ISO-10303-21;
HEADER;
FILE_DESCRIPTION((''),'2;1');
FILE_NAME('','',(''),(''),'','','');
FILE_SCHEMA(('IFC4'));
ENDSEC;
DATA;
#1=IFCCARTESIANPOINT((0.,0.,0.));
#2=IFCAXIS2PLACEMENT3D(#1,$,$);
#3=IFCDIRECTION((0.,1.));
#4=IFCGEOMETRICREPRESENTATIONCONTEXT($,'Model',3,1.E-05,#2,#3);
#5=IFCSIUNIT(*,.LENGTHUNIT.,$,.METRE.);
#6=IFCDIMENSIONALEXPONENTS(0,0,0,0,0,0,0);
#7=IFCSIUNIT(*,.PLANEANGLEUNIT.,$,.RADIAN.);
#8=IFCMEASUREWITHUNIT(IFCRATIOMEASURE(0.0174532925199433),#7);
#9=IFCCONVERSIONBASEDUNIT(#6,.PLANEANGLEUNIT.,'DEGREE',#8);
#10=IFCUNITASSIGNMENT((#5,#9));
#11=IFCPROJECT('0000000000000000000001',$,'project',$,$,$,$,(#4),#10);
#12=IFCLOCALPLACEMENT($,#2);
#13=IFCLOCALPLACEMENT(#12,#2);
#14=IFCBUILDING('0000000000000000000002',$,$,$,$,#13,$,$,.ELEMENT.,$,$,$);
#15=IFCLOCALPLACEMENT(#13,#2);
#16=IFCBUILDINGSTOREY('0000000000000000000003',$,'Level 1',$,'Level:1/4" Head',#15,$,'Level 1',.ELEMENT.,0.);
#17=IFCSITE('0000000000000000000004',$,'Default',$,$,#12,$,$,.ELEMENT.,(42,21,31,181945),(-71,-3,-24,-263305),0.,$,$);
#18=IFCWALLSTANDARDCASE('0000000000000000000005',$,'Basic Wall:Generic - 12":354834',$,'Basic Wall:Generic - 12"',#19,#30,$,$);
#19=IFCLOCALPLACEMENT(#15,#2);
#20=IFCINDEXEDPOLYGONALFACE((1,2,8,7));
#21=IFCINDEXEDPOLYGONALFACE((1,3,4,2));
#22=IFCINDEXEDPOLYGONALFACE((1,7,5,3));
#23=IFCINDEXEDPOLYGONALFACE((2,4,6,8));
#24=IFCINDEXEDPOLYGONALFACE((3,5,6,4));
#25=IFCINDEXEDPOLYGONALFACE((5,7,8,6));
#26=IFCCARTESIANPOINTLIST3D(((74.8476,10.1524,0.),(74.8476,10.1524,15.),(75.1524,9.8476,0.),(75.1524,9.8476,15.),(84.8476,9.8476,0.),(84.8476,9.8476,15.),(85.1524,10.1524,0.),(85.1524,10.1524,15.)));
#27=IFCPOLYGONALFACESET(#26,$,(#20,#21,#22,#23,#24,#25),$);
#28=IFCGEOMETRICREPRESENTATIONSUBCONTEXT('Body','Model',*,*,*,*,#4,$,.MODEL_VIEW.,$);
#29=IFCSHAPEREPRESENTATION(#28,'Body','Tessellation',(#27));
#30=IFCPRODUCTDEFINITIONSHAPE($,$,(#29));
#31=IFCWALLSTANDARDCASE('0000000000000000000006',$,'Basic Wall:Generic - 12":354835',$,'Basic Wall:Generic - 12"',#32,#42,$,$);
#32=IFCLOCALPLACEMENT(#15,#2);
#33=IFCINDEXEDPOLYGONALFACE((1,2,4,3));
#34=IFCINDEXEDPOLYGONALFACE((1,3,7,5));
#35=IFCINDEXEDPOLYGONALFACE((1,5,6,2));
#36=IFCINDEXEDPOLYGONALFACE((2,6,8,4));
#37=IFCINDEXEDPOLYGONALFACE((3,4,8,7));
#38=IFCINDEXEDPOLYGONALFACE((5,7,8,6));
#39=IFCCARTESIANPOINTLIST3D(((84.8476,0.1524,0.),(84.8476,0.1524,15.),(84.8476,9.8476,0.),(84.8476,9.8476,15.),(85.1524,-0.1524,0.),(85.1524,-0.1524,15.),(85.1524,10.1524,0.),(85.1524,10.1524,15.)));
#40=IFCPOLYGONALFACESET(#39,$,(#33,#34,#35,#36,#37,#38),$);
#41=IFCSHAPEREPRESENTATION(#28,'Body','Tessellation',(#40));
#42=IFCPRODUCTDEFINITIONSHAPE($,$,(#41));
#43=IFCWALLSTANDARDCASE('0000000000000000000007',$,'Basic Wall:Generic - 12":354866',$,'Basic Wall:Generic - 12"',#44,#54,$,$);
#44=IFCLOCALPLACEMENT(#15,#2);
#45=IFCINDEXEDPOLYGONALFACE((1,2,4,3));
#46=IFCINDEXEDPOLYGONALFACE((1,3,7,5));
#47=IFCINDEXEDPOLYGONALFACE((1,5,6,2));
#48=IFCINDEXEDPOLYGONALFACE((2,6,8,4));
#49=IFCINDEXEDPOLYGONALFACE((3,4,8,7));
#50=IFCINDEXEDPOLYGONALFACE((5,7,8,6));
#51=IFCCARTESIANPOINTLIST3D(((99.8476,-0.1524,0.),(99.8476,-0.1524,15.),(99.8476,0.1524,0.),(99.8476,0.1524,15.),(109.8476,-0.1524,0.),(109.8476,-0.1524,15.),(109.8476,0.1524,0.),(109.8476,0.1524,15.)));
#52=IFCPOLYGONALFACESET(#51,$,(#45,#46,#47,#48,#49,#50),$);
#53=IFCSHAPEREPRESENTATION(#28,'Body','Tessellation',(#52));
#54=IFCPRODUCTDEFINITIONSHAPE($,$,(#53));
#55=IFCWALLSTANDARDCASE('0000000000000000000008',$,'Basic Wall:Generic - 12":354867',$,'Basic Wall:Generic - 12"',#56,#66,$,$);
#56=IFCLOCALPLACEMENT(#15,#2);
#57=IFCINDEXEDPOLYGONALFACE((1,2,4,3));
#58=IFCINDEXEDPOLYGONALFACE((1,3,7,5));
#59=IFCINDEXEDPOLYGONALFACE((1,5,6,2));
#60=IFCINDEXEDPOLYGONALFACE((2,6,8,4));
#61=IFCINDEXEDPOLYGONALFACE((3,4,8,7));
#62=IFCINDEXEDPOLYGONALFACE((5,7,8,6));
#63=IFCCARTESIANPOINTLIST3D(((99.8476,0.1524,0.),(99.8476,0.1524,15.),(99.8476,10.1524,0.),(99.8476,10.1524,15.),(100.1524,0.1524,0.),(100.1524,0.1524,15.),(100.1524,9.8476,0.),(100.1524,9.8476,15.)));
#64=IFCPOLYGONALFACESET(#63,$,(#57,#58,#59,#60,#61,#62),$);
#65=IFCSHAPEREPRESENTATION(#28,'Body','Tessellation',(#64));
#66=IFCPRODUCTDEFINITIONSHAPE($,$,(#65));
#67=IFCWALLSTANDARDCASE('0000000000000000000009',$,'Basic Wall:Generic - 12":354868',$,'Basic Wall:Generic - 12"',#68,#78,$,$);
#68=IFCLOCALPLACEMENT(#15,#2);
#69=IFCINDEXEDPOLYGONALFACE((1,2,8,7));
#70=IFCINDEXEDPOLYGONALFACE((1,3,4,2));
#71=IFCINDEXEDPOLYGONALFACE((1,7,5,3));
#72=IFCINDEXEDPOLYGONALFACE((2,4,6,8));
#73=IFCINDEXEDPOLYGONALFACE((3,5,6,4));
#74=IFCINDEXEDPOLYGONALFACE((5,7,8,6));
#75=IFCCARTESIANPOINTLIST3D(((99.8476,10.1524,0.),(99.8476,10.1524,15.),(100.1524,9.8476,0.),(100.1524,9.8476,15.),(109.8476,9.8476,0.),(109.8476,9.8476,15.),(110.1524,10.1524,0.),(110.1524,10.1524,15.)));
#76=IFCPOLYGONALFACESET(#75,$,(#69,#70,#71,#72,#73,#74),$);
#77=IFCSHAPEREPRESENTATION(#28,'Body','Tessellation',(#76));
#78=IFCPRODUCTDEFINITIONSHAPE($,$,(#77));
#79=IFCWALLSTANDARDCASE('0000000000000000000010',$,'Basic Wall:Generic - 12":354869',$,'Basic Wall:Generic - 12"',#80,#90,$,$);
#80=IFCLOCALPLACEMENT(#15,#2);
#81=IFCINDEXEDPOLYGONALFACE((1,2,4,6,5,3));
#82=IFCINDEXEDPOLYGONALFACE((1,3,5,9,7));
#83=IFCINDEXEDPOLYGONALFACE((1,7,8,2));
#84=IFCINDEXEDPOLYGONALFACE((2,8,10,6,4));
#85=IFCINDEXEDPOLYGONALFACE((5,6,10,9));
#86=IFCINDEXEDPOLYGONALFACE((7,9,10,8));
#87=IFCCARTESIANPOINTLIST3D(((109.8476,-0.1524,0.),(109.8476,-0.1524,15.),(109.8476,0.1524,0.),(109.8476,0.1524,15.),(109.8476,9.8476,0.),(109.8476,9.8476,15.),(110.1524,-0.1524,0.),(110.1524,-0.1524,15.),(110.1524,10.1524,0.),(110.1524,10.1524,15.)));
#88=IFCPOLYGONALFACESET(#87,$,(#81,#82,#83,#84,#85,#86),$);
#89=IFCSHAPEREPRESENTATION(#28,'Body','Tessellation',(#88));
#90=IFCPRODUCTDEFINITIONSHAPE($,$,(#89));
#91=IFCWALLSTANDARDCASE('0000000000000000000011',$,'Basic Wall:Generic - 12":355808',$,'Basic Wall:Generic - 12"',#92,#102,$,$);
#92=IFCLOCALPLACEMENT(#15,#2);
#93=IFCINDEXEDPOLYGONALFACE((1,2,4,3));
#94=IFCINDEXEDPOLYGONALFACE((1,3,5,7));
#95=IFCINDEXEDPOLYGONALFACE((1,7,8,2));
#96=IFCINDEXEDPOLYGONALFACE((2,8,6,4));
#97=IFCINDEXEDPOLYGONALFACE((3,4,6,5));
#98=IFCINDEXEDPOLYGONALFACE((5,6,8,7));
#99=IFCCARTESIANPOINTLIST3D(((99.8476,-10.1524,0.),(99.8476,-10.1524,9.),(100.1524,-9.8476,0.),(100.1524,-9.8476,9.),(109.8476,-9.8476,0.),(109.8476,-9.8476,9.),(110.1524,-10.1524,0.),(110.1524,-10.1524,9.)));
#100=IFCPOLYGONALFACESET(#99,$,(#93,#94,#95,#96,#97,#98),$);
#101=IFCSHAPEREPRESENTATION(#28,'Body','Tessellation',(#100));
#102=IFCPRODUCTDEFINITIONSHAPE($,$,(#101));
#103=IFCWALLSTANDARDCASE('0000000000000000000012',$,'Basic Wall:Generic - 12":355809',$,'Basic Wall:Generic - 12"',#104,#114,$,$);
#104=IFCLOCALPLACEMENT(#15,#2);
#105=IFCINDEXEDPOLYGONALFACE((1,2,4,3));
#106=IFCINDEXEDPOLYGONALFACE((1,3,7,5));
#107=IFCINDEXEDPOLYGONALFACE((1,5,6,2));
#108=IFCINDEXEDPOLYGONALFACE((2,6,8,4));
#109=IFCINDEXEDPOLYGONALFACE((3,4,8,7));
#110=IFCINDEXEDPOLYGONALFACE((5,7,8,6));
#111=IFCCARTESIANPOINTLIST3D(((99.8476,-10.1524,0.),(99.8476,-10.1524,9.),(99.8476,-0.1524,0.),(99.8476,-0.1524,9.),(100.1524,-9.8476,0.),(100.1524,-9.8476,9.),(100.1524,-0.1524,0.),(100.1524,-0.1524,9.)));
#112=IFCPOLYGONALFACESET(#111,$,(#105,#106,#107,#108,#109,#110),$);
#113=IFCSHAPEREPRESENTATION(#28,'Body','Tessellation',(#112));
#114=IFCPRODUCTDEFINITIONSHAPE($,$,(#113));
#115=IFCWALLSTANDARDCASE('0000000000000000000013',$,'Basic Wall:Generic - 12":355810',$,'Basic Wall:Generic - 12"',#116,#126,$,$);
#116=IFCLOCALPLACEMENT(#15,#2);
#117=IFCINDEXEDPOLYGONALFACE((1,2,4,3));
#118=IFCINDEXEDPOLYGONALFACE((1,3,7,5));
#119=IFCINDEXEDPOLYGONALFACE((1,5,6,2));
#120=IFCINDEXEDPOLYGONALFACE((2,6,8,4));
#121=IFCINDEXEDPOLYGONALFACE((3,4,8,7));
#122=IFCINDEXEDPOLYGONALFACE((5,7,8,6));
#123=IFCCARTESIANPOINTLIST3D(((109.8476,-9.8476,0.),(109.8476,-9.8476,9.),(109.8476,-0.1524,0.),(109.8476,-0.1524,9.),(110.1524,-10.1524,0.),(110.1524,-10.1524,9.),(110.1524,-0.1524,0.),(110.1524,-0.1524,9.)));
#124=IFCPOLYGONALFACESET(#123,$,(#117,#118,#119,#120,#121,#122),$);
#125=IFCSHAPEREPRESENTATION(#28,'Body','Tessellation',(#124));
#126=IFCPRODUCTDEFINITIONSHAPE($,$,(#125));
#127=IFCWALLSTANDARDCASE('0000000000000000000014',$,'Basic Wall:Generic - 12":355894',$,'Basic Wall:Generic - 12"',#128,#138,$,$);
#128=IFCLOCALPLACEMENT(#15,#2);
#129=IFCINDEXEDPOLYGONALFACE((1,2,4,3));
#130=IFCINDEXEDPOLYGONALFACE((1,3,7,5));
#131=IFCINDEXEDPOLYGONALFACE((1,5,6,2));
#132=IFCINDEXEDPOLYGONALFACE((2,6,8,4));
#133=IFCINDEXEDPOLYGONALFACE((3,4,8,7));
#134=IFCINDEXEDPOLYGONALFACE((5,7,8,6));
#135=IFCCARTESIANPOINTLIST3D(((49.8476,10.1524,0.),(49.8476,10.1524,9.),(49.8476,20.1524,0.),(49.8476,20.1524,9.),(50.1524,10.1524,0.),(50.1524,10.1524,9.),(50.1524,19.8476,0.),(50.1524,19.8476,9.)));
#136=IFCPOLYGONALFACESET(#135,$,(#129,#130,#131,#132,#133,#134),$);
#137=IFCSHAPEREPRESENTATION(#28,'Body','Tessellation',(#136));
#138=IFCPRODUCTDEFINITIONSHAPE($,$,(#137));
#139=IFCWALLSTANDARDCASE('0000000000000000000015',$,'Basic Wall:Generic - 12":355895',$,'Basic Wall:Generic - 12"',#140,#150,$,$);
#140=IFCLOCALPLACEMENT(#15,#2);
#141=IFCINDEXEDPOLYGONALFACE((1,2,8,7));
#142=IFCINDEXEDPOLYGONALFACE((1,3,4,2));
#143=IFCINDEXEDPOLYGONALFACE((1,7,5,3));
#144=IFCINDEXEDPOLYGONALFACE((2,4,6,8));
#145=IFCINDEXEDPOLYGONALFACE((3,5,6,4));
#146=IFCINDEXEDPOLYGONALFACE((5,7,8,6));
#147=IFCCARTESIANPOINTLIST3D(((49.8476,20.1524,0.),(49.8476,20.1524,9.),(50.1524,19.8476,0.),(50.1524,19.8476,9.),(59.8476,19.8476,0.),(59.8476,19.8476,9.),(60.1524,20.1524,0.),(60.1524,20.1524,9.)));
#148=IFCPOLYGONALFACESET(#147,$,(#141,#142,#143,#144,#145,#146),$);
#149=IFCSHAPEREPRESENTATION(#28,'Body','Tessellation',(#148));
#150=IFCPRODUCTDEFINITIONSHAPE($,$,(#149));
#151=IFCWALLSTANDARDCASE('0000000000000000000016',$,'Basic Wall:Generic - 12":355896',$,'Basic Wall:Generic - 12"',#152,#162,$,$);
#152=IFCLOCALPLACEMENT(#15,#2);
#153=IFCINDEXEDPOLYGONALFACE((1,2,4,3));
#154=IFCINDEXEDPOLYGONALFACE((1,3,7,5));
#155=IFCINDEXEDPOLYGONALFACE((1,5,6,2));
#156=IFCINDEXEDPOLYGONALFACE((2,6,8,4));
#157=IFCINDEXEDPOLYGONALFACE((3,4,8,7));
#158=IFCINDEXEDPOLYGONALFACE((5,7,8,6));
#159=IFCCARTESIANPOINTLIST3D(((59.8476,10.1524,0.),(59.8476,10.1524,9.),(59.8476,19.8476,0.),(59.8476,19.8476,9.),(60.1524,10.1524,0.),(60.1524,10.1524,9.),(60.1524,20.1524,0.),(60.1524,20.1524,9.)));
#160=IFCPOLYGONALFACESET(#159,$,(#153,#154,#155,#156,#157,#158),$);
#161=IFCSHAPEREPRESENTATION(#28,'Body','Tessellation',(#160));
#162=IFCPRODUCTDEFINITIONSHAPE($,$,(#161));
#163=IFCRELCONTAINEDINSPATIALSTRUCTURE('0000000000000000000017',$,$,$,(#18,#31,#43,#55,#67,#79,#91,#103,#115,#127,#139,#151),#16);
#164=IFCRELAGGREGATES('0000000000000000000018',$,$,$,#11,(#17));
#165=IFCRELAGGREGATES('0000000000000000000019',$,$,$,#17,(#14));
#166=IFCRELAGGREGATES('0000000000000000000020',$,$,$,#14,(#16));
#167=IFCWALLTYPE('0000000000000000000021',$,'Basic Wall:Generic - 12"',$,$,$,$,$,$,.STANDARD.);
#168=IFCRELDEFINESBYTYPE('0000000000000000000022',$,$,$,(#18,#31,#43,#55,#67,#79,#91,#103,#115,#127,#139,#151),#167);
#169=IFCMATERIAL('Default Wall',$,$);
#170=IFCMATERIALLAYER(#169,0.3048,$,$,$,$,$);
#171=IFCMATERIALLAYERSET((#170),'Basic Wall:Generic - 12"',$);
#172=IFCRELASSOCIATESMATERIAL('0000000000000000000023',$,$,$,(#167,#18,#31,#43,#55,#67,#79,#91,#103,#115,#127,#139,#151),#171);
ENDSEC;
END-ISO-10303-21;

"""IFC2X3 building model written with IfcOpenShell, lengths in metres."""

from ifc_helpers import new_model, entity, si_unit, converted_unit, direction, frame, frame_2d, origin, place, context, subcontext, project, spatial, polyline, rectangle, outline, extrude, material, layer, layer_set, layer_usage, type_object, element, save


model = new_model("IFC2X3")

# Units and contexts
model_context = context("Model", 3, precision=1e-05, world=origin(), true_north=direction((0.0, 1.0)))
body_context = subcontext(model_context, "Body", "Model", "MODEL_VIEW")
ifc_project = project(units=[si_unit("LENGTHUNIT", "METRE"), converted_unit("PLANEANGLEUNIT", "DEGREE", entity("IfcRatioMeasure", 0.0174532925199433), si_unit("PLANEANGLEUNIT", "RADIAN"), dimensions=[0, 0, 0, 0, 0, 0, 0])], contexts=[model_context])

# Site, building, storey
site_placement = place(None, origin())
site = spatial("IfcSite", under=ifc_project, at=site_placement, Name="Default", CompositionType="ELEMENT", RefLatitude=(42, 21, 31, 181945), RefLongitude=(-71, -3, -24, -263305), RefElevation=0.0)
building_placement = place(site_placement, origin())
building = spatial("IfcBuilding", under=site, at=building_placement, CompositionType="ELEMENT")
storey_placement = place(building_placement, origin())
storey = spatial("IfcBuildingStorey", under=building, at=storey_placement, Name="Level 1", ObjectType="Level:1/4\" Head", LongName="Level 1", CompositionType="ELEMENT", Elevation=0.0)

# Walls
ifc_material = material(Name="Default Wall")
ifc_layer = layer(ifc_material, 0.3048)
ifc_layer_set = layer_set([ifc_layer], Name="Basic Wall:Generic - 12\"")
wall_type = type_object("IfcWallType", Name="Basic Wall:Generic - 12\"", PredefinedType="STANDARD", material=ifc_layer_set)
ifc_layer_usage_1 = layer_usage(ifc_layer_set, "AXIS2", "NEGATIVE", 0.1524)
wall_1_placement = place(storey_placement, frame((85.1524, 10.0, 0.0), z_axis=(0.0, 0.0, 1.0), x_axis=(-1.0, 0.0, 0.0)))
element("IfcWallStandardCase", 1, at=wall_1_placement, inside=storey, type_object=wall_type, material=ifc_layer_usage_1, Name="Basic Wall:Generic - 12\":354834", ObjectType="Basic Wall:Generic - 12\"", context=body_context, shape_type="SweptSolid", body=[
    extrude(outline(polyline([(10.3048, -0.1524), (10.0, 0.1524), (0.3048, 0.1524), (0.0, -0.1524), (10.3048, -0.1524)])), origin(), (0.0, 0.0, 1.0), 15.0),
])
ifc_layer_usage_2 = layer_usage(ifc_layer_set, "AXIS2", "NEGATIVE", 0.1524)
wall_2_placement = place(storey_placement, frame((85.0, -0.1524, 0.0), z_axis=(0.0, 0.0, 1.0), x_axis=(0.0, 1.0, 0.0)))
element("IfcWallStandardCase", 2, at=wall_2_placement, inside=storey, type_object=wall_type, material=ifc_layer_usage_2, Name="Basic Wall:Generic - 12\":354835", ObjectType="Basic Wall:Generic - 12\"", context=body_context, shape_type="SweptSolid", body=[
    extrude(outline(polyline([(10.3048, -0.1524), (10.0, 0.1524), (0.3048, 0.1524), (0.0, -0.1524), (10.3048, -0.1524)])), origin(), (0.0, 0.0, 1.0), 15.0),
])
ifc_layer_usage_3 = layer_usage(ifc_layer_set, "AXIS2", "NEGATIVE", 0.1524)
wall_3_placement = place(storey_placement, frame((99.8476, 0.0, 0.0)))
element("IfcWallStandardCase", 3, at=wall_3_placement, inside=storey, type_object=wall_type, material=ifc_layer_usage_3, Name="Basic Wall:Generic - 12\":354866", ObjectType="Basic Wall:Generic - 12\"", context=body_context, shape_type="SweptSolid", body=[
    extrude(rectangle(XDim=10.0, YDim=0.3048, at=frame_2d((5.0, 0.0), x_axis=(-1.0, 0.0))), origin(), (0.0, 0.0, 1.0), 15.0),
])
ifc_layer_usage_4 = layer_usage(ifc_layer_set, "AXIS2", "NEGATIVE", 0.1524)
wall_4_placement = place(storey_placement, frame((100.0, 10.1524, 0.0), z_axis=(0.0, 0.0, 1.0), x_axis=(0.0, -1.0, 0.0)))
element("IfcWallStandardCase", 4, at=wall_4_placement, inside=storey, type_object=wall_type, material=ifc_layer_usage_4, Name="Basic Wall:Generic - 12\":354867", ObjectType="Basic Wall:Generic - 12\"", context=body_context, shape_type="SweptSolid", body=[
    extrude(outline(polyline([(10.0, -0.1524), (10.0, 0.1524), (0.3048, 0.1524), (0.0, -0.1524), (10.0, -0.1524)])), origin(), (0.0, 0.0, 1.0), 15.0),
])
ifc_layer_usage_5 = layer_usage(ifc_layer_set, "AXIS2", "NEGATIVE", 0.1524)
wall_5_placement = place(storey_placement, frame((110.1524, 10.0, 0.0), z_axis=(0.0, 0.0, 1.0), x_axis=(-1.0, 0.0, 0.0)))
element("IfcWallStandardCase", 5, at=wall_5_placement, inside=storey, type_object=wall_type, material=ifc_layer_usage_5, Name="Basic Wall:Generic - 12\":354868", ObjectType="Basic Wall:Generic - 12\"", context=body_context, shape_type="SweptSolid", body=[
    extrude(outline(polyline([(10.3048, -0.1524), (10.0, 0.1524), (0.3048, 0.1524), (0.0, -0.1524), (10.3048, -0.1524)])), origin(), (0.0, 0.0, 1.0), 15.0),
])
ifc_layer_usage_6 = layer_usage(ifc_layer_set, "AXIS2", "NEGATIVE", 0.1524)
wall_6_placement = place(storey_placement, frame((110.0, -0.1524, 0.0), z_axis=(0.0, 0.0, 1.0), x_axis=(0.0, 1.0, 0.0)))
element("IfcWallStandardCase", 6, at=wall_6_placement, inside=storey, type_object=wall_type, material=ifc_layer_usage_6, Name="Basic Wall:Generic - 12\":354869", ObjectType="Basic Wall:Generic - 12\"", context=body_context, shape_type="SweptSolid", body=[
    extrude(outline(polyline([(10.3048, -0.1524), (10.0, 0.1524), (0.3048, 0.1524), (0.0, 0.1524), (0.0, -0.1524), (10.3048, -0.1524)])), origin(), (0.0, 0.0, 1.0), 15.0),
])
ifc_layer_usage_7 = layer_usage(ifc_layer_set, "AXIS2", "NEGATIVE", 0.1524)
wall_7_placement = place(storey_placement, frame((99.8476, -10.0, 0.0)))
element("IfcWallStandardCase", 7, at=wall_7_placement, inside=storey, type_object=wall_type, material=ifc_layer_usage_7, Name="Basic Wall:Generic - 12\":355808", ObjectType="Basic Wall:Generic - 12\"", context=body_context, shape_type="SweptSolid", body=[
    extrude(outline(polyline([(10.3048, -0.1524), (10.0, 0.1524), (0.3048, 0.1524), (0.0, -0.1524), (10.3048, -0.1524)])), origin(), (0.0, 0.0, 1.0), 9.0),
])
ifc_layer_usage_8 = layer_usage(ifc_layer_set, "AXIS2", "NEGATIVE", 0.1524)
wall_8_placement = place(storey_placement, frame((100.0, -0.1524, 0.0), z_axis=(0.0, 0.0, 1.0), x_axis=(0.0, -1.0, 0.0)))
element("IfcWallStandardCase", 8, at=wall_8_placement, inside=storey, type_object=wall_type, material=ifc_layer_usage_8, Name="Basic Wall:Generic - 12\":355809", ObjectType="Basic Wall:Generic - 12\"", context=body_context, shape_type="SweptSolid", body=[
    extrude(outline(polyline([(10.0, -0.1524), (9.6952, 0.1524), (0.0, 0.1524), (0.0, -0.1524), (10.0, -0.1524)])), origin(), (0.0, 0.0, 1.0), 9.0),
])
ifc_layer_usage_9 = layer_usage(ifc_layer_set, "AXIS2", "NEGATIVE", 0.1524)
wall_9_placement = place(storey_placement, frame((110.0, -10.1524, 0.0), z_axis=(0.0, 0.0, 1.0), x_axis=(0.0, 1.0, 0.0)))
element("IfcWallStandardCase", 9, at=wall_9_placement, inside=storey, type_object=wall_type, material=ifc_layer_usage_9, Name="Basic Wall:Generic - 12\":355810", ObjectType="Basic Wall:Generic - 12\"", context=body_context, shape_type="SweptSolid", body=[
    extrude(outline(polyline([(10.0, -0.1524), (10.0, 0.1524), (0.3048, 0.1524), (0.0, -0.1524), (10.0, -0.1524)])), origin(), (0.0, 0.0, 1.0), 9.0),
])
ifc_layer_usage_10 = layer_usage(ifc_layer_set, "AXIS2", "NEGATIVE", 0.1524)
wall_10_placement = place(storey_placement, frame((50.0, 20.1524, 0.0), z_axis=(0.0, 0.0, 1.0), x_axis=(0.0, -1.0, 0.0)))
element("IfcWallStandardCase", 10, at=wall_10_placement, inside=storey, type_object=wall_type, material=ifc_layer_usage_10, Name="Basic Wall:Generic - 12\":355894", ObjectType="Basic Wall:Generic - 12\"", context=body_context, shape_type="SweptSolid", body=[
    extrude(outline(polyline([(10.0, -0.1524), (10.0, 0.1524), (0.3048, 0.1524), (0.0, -0.1524), (10.0, -0.1524)])), origin(), (0.0, 0.0, 1.0), 9.0),
])
ifc_layer_usage_11 = layer_usage(ifc_layer_set, "AXIS2", "NEGATIVE", 0.1524)
wall_11_placement = place(storey_placement, frame((60.1524, 20.0, 0.0), z_axis=(0.0, 0.0, 1.0), x_axis=(-1.0, 0.0, 0.0)))
element("IfcWallStandardCase", 11, at=wall_11_placement, inside=storey, type_object=wall_type, material=ifc_layer_usage_11, Name="Basic Wall:Generic - 12\":355895", ObjectType="Basic Wall:Generic - 12\"", context=body_context, shape_type="SweptSolid", body=[
    extrude(outline(polyline([(10.3048, -0.1524), (10.0, 0.1524), (0.3048, 0.1524), (0.0, -0.1524), (10.3048, -0.1524)])), origin(), (0.0, 0.0, 1.0), 9.0),
])
ifc_layer_usage_12 = layer_usage(ifc_layer_set, "AXIS2", "NEGATIVE", 0.1524)
wall_12_placement = place(storey_placement, frame((60.0, 10.1524, 0.0), z_axis=(0.0, 0.0, 1.0), x_axis=(0.0, 1.0, 0.0)))
element("IfcWallStandardCase", 12, at=wall_12_placement, inside=storey, type_object=wall_type, material=ifc_layer_usage_12, Name="Basic Wall:Generic - 12\":355896", ObjectType="Basic Wall:Generic - 12\"", context=body_context, shape_type="SweptSolid", body=[
    extrude(outline(polyline([(10.0, -0.1524), (9.6952, 0.1524), (0.0, 0.1524), (0.0, -0.1524), (10.0, -0.1524)])), origin(), (0.0, 0.0, 1.0), 9.0),
])

save(model, "model.ifc")
